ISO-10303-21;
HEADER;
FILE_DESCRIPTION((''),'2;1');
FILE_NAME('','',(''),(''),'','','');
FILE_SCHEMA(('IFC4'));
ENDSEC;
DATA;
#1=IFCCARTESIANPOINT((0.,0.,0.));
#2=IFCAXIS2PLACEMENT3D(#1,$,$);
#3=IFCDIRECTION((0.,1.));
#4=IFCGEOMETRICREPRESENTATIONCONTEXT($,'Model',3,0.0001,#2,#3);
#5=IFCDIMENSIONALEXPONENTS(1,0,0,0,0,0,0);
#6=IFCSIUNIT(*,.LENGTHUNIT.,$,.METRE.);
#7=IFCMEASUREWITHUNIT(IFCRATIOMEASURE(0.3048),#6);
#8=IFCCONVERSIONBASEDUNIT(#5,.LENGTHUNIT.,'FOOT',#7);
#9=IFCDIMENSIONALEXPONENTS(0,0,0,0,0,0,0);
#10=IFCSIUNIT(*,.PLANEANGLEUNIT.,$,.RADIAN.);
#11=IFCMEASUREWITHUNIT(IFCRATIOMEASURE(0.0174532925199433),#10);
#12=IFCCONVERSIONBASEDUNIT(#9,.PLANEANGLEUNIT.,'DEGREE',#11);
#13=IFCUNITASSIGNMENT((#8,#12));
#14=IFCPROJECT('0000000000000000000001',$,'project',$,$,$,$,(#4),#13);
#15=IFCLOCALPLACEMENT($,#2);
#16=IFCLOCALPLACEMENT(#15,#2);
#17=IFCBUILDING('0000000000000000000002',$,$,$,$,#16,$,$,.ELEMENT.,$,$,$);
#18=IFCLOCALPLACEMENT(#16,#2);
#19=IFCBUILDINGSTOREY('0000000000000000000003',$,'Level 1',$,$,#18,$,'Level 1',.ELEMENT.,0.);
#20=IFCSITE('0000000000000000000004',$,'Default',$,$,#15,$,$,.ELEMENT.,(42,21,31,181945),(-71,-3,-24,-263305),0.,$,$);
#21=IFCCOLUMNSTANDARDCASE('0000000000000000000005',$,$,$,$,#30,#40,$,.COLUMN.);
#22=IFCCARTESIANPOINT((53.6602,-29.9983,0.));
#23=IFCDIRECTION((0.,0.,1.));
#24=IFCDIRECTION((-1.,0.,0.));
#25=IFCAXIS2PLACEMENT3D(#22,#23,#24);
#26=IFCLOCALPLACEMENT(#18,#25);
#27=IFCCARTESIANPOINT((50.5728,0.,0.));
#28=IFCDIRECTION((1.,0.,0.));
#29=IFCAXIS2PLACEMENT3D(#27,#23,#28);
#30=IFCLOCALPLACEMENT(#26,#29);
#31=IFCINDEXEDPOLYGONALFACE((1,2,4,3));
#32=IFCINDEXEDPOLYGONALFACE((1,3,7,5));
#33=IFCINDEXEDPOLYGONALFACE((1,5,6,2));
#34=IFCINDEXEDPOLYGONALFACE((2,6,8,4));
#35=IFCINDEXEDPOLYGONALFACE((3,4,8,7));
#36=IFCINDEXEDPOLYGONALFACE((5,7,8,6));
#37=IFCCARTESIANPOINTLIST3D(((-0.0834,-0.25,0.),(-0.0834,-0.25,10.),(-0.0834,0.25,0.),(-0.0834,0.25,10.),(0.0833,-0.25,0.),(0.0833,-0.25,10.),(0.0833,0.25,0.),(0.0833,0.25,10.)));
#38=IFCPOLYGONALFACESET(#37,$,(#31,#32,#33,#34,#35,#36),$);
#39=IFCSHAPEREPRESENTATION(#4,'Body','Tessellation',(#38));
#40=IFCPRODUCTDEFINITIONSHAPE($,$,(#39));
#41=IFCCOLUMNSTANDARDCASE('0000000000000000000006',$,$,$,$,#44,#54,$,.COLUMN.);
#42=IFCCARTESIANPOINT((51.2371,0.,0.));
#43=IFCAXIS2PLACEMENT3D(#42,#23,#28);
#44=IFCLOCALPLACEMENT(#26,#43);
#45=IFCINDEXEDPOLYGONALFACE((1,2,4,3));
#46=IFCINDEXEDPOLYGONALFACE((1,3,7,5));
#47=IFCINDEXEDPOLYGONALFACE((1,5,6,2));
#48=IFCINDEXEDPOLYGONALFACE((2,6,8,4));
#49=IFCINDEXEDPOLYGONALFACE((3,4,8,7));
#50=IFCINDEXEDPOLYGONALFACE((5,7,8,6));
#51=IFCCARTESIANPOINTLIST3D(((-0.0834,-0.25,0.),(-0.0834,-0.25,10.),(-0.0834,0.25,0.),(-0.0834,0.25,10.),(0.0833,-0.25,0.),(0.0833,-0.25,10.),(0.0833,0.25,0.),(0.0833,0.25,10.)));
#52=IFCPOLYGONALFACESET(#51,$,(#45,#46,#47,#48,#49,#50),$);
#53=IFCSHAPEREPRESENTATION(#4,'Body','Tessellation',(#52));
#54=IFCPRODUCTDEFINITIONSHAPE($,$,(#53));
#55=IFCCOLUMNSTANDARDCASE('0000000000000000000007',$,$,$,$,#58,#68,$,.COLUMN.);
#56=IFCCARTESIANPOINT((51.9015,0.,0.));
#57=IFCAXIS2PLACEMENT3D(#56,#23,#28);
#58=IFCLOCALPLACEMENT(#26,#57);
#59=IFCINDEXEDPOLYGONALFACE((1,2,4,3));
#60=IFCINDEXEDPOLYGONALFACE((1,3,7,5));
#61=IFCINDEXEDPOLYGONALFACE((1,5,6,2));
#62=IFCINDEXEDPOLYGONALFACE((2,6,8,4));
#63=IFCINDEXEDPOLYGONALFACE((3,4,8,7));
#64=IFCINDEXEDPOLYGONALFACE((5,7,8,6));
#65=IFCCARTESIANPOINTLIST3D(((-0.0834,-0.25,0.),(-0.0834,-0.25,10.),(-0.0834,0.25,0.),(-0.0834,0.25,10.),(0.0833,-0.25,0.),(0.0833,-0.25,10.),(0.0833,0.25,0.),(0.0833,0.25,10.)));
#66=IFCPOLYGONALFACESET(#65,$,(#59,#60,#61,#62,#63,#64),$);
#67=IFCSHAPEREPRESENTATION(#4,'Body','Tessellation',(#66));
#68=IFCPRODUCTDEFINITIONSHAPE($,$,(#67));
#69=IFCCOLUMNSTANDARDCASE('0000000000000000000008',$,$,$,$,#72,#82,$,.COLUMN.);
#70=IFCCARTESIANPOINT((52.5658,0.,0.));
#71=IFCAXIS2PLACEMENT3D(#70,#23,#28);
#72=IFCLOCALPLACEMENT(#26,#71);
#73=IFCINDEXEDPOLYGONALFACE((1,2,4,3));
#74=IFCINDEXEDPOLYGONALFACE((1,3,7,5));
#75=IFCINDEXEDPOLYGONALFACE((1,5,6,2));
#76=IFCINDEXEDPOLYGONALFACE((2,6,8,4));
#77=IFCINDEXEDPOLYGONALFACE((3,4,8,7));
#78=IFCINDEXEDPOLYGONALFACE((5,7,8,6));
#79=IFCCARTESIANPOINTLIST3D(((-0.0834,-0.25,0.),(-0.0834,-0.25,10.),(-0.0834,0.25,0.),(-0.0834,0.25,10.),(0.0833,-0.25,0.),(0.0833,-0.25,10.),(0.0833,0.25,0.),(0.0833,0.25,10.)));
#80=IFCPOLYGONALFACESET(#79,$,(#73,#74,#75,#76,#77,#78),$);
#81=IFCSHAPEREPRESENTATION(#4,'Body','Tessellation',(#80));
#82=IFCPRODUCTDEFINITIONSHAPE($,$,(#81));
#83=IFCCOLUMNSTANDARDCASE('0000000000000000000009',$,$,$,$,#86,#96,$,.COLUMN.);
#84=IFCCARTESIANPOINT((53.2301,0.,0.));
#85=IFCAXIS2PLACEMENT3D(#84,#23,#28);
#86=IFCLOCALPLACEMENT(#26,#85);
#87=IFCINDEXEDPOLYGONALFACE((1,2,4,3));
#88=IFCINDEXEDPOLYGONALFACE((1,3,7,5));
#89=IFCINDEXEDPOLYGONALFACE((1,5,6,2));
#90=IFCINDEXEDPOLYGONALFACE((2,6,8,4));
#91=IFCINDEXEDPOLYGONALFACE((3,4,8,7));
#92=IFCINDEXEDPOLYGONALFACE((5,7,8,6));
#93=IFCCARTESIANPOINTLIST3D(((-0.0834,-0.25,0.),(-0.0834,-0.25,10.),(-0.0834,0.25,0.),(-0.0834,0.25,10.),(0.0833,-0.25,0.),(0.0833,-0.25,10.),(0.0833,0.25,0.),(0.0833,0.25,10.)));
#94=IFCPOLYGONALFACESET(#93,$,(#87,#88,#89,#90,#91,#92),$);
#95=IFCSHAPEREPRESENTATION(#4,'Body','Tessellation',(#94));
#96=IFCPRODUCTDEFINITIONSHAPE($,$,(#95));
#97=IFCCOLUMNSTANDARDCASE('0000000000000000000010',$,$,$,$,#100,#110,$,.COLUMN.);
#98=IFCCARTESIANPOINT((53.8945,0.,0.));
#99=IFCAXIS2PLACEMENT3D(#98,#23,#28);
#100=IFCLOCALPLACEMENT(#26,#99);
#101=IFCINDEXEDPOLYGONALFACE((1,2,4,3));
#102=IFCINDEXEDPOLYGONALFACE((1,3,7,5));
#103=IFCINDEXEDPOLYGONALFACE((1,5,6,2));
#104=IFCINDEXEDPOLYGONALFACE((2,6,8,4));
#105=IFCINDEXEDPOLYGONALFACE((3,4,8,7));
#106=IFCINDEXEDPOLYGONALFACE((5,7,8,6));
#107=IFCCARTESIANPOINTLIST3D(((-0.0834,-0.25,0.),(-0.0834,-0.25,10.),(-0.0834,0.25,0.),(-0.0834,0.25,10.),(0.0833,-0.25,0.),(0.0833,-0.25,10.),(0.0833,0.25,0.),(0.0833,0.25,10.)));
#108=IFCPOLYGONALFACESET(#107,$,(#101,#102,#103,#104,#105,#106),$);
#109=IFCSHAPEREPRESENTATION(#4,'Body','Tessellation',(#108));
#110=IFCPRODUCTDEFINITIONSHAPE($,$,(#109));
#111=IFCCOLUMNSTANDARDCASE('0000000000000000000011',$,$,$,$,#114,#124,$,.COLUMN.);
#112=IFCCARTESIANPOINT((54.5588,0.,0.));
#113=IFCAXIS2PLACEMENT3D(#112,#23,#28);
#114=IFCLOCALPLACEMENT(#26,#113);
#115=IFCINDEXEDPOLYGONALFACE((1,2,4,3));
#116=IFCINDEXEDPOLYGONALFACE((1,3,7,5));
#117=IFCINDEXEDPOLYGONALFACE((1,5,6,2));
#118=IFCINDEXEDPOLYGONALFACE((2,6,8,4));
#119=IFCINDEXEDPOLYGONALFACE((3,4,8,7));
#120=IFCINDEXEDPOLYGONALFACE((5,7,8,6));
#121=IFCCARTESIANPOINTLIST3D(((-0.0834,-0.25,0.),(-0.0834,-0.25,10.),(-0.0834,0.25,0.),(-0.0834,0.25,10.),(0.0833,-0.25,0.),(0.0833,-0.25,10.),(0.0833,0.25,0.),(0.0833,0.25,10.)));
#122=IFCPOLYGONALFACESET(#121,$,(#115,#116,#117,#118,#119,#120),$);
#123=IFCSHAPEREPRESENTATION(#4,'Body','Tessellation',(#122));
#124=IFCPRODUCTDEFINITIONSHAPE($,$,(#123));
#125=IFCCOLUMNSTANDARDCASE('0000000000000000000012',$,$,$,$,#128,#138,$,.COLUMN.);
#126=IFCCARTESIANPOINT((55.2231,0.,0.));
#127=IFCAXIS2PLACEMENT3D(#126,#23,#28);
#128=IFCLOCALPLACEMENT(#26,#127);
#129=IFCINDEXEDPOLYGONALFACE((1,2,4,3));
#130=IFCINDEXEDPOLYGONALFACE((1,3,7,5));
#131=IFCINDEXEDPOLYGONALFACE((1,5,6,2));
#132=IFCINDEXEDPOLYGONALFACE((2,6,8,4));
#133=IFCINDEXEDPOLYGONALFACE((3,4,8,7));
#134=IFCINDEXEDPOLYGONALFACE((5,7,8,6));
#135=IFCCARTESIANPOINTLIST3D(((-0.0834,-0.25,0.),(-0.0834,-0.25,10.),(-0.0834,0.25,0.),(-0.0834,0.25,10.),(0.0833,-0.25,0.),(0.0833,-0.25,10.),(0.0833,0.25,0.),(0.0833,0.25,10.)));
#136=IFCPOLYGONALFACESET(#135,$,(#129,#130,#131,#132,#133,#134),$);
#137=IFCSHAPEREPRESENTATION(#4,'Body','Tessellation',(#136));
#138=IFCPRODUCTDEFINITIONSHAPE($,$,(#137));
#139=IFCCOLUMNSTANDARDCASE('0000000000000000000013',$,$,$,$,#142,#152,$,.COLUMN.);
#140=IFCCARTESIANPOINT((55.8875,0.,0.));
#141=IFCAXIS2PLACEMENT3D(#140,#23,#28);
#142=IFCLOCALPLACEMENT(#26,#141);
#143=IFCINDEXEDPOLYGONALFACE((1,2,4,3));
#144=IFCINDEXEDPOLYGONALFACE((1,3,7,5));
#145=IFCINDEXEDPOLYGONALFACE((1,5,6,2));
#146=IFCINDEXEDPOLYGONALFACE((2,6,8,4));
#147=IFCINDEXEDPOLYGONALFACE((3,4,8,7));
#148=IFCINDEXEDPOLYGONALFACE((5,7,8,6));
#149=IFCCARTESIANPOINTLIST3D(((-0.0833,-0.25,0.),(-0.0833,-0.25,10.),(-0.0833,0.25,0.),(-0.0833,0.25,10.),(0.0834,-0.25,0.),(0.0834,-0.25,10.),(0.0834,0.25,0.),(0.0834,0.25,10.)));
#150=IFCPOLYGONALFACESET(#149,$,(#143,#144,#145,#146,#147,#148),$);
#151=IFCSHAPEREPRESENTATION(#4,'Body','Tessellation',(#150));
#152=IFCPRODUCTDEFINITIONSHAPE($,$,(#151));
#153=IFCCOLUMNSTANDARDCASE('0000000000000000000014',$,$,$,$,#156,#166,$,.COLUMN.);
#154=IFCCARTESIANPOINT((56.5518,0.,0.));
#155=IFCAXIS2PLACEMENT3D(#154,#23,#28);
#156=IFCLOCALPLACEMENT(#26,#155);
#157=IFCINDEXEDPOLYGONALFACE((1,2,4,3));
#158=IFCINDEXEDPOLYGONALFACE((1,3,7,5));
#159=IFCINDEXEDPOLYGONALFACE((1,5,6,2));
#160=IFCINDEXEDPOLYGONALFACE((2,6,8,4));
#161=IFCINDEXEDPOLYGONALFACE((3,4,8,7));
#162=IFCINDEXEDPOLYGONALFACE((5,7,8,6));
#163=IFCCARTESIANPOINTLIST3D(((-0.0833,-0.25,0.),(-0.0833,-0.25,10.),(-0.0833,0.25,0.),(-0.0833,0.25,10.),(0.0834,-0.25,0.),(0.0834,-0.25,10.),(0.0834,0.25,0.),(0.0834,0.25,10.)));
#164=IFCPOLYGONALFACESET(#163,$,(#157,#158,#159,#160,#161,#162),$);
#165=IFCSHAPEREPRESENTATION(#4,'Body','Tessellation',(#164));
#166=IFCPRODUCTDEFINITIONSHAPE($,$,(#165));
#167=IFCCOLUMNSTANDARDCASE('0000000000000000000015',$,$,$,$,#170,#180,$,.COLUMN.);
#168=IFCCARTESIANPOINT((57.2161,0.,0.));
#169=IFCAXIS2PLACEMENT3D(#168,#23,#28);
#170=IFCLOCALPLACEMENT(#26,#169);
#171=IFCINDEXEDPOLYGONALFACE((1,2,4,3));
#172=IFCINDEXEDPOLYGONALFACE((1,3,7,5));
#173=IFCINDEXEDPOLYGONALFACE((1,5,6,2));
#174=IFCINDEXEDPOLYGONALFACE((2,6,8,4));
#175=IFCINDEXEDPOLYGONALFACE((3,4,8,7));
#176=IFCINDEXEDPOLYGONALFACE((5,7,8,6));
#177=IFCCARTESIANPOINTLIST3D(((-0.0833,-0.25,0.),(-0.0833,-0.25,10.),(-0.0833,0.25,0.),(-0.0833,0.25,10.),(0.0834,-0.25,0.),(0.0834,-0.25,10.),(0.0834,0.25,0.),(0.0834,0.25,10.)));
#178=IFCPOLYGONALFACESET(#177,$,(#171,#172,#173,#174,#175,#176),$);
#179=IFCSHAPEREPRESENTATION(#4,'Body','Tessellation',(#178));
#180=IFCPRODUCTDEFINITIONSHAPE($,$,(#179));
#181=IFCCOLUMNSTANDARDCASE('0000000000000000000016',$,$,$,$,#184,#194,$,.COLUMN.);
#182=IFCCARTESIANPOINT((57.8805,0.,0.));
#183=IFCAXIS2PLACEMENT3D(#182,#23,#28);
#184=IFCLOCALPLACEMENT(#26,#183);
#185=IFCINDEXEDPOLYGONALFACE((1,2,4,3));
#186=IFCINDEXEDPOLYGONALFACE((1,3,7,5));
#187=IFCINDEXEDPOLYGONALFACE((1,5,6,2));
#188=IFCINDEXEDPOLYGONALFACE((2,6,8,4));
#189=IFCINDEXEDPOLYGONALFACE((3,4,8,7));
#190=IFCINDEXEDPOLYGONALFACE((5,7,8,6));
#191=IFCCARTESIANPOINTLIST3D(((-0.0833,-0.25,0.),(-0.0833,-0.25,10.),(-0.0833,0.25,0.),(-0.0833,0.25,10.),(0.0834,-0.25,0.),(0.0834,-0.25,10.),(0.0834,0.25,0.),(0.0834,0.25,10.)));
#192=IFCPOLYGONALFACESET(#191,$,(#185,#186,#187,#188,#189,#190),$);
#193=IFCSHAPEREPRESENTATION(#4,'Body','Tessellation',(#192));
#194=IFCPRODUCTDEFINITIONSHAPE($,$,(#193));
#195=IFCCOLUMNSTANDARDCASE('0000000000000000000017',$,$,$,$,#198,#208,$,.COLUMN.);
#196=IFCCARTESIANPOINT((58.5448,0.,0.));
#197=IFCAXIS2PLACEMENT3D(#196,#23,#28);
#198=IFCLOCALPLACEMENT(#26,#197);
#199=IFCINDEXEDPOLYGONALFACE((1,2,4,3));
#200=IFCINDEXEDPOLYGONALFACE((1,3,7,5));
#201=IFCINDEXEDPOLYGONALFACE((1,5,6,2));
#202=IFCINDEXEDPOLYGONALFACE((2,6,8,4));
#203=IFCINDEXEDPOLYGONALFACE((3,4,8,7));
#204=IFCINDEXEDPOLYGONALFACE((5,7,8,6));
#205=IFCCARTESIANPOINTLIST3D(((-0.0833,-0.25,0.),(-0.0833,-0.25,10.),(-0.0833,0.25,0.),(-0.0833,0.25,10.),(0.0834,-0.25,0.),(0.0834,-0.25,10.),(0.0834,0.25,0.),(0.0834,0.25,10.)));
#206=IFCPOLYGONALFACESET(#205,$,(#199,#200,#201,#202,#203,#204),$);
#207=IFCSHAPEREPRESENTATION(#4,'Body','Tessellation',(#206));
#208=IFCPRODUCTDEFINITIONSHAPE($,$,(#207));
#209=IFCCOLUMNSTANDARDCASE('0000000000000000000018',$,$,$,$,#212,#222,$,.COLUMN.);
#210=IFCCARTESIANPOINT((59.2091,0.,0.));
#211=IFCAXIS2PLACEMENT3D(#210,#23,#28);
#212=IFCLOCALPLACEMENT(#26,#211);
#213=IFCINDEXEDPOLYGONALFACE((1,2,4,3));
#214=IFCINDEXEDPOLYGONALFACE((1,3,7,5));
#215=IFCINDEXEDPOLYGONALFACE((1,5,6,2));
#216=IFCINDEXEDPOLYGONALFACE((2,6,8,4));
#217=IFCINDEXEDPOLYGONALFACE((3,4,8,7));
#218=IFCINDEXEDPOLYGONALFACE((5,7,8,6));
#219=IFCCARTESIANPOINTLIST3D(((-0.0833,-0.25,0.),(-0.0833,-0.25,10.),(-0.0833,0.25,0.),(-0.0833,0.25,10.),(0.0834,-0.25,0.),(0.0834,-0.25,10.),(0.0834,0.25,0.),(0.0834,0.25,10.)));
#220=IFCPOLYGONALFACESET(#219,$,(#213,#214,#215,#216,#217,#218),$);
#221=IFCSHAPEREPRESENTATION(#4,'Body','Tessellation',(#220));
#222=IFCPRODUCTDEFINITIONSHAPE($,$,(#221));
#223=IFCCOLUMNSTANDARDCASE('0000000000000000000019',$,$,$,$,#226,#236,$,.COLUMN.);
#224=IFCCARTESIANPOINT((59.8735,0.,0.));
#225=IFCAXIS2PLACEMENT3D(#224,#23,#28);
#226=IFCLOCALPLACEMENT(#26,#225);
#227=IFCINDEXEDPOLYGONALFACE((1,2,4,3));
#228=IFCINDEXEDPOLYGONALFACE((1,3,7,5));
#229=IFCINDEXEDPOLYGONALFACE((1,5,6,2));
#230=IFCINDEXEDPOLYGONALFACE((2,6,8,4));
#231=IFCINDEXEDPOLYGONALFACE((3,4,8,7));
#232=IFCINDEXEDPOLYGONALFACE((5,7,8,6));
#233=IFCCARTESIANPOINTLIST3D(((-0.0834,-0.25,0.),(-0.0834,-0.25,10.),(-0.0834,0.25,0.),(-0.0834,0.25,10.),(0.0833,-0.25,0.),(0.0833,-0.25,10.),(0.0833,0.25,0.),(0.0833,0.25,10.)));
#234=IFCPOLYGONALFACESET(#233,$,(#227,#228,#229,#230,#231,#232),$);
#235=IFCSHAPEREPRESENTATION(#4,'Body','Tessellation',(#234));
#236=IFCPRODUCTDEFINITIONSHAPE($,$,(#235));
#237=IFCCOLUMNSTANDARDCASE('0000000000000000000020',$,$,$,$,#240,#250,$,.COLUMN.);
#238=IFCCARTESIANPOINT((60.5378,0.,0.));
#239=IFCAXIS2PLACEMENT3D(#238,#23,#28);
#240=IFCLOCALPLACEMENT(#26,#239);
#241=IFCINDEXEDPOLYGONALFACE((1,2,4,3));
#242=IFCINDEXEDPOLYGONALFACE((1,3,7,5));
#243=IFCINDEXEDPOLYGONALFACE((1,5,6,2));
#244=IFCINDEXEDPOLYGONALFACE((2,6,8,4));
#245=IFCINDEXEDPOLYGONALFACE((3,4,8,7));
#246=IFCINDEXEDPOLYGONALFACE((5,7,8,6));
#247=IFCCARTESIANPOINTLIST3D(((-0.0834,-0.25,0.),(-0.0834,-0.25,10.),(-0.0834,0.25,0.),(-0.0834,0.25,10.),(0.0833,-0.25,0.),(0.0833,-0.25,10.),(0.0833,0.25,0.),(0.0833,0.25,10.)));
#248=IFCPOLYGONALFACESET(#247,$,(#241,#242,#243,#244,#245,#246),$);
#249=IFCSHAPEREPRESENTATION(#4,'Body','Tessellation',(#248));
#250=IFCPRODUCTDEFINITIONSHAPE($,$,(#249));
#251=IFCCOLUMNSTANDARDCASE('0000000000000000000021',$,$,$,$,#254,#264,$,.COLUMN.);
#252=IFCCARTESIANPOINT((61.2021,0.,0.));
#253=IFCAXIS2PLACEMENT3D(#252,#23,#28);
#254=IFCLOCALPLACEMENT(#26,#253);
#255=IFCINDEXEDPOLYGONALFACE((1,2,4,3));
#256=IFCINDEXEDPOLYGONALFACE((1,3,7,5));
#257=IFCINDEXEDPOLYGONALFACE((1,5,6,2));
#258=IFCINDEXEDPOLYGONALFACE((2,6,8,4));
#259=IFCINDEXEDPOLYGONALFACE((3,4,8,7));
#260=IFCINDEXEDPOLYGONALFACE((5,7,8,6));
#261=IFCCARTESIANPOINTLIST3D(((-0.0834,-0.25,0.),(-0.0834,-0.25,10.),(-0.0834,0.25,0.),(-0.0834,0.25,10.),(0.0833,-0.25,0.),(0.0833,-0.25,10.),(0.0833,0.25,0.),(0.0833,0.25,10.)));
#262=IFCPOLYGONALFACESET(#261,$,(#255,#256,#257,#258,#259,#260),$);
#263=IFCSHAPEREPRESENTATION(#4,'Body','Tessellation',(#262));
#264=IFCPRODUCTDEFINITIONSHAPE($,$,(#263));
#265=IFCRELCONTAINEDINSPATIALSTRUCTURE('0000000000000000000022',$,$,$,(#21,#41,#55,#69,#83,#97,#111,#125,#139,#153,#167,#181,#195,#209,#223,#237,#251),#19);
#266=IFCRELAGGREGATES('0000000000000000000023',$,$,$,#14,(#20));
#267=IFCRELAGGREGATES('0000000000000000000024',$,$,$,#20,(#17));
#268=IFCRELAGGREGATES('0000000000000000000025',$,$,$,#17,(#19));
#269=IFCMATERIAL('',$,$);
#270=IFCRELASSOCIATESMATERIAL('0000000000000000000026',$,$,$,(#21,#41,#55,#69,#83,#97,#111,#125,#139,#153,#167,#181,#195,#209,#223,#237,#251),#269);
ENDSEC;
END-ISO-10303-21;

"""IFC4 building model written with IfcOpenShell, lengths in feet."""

from ifc_helpers import new_model, entity, si_unit, converted_unit, direction, frame, origin, place, context, project, spatial, rectangle, extrude, material, element, save


model = new_model("IFC4")

# Units and contexts
model_context = context("Model", 3, precision=0.0001, world=origin(), true_north=direction((0.0, 1.0)))
ifc_project = project(units=[converted_unit("LENGTHUNIT", "FOOT", entity("IfcRatioMeasure", 0.3048), si_unit("LENGTHUNIT", "METRE"), dimensions=[1, 0, 0, 0, 0, 0, 0]), converted_unit("PLANEANGLEUNIT", "DEGREE", entity("IfcRatioMeasure", 0.0174532925199433), si_unit("PLANEANGLEUNIT", "RADIAN"), dimensions=[0, 0, 0, 0, 0, 0, 0])], contexts=[model_context])

# Site, building, storey
site_placement = place(None, origin())
site = spatial("IfcSite", under=ifc_project, at=site_placement, Name="Default", CompositionType="ELEMENT", RefLatitude=(42, 21, 31, 181945), RefLongitude=(-71, -3, -24, -263305), RefElevation=0.0)
building_placement = place(site_placement, origin())
building = spatial("IfcBuilding", under=site, at=building_placement, CompositionType="ELEMENT")
storey_placement = place(building_placement, origin())
storey = spatial("IfcBuildingStorey", under=building, at=storey_placement, Name="Level 1", LongName="Level 1", CompositionType="ELEMENT", Elevation=0.0)

# Columns
ifc_material = material(Name="")
placement = place(storey_placement, frame((53.6602, -29.9983, 0.0), z_axis=(0.0, 0.0, 1.0), x_axis=(-1.0, 0.0, 0.0)))
for number, where, z_axis, x_axis in (
    (1, (50.5728, 0.0, 0.0), (0.0, 0.0, 1.0), (1.0, 0.0, 0.0)),
    (2, (51.2371, 0.0, 0.0), (0.0, 0.0, 1.0), (1.0, 0.0, 0.0)),
    (3, (51.9015, 0.0, 0.0), (0.0, 0.0, 1.0), (1.0, 0.0, 0.0)),
    (4, (52.5658, 0.0, 0.0), (0.0, 0.0, 1.0), (1.0, 0.0, 0.0)),
    (5, (53.2301, 0.0, 0.0), (0.0, 0.0, 1.0), (1.0, 0.0, 0.0)),
    (6, (53.8945, 0.0, 0.0), (0.0, 0.0, 1.0), (1.0, 0.0, 0.0)),
    (7, (54.5588, 0.0, 0.0), (0.0, 0.0, 1.0), (1.0, 0.0, 0.0)),
    (8, (55.2231, 0.0, 0.0), (0.0, 0.0, 1.0), (1.0, 0.0, 0.0)),
    (9, (55.8875, 0.0, 0.0), (0.0, 0.0, 1.0), (1.0, 0.0, 0.0)),
    (10, (56.5518, 0.0, 0.0), (0.0, 0.0, 1.0), (1.0, 0.0, 0.0)),
    (11, (57.2161, 0.0, 0.0), (0.0, 0.0, 1.0), (1.0, 0.0, 0.0)),
    (12, (57.8805, 0.0, 0.0), (0.0, 0.0, 1.0), (1.0, 0.0, 0.0)),
    (13, (58.5448, 0.0, 0.0), (0.0, 0.0, 1.0), (1.0, 0.0, 0.0)),
    (14, (59.2091, 0.0, 0.0), (0.0, 0.0, 1.0), (1.0, 0.0, 0.0)),
    (15, (59.8735, 0.0, 0.0), (0.0, 0.0, 1.0), (1.0, 0.0, 0.0)),
    (16, (60.5378, 0.0, 0.0), (0.0, 0.0, 1.0), (1.0, 0.0, 0.0)),
    (17, (61.2021, 0.0, 0.0), (0.0, 0.0, 1.0), (1.0, 0.0, 0.0)),
):
    element("IfcColumnStandardCase", number, at=place(placement, frame(where, z_axis=z_axis, x_axis=x_axis)), inside=storey, material=ifc_material, PredefinedType="COLUMN", context=model_context, shape_type="SweptSolid", body=[
        extrude(rectangle(XDim=0.1667, YDim=0.5), origin(), (0.0, 0.0, 1.0), 10.0),
    ])

save(model, "model.ifc")
